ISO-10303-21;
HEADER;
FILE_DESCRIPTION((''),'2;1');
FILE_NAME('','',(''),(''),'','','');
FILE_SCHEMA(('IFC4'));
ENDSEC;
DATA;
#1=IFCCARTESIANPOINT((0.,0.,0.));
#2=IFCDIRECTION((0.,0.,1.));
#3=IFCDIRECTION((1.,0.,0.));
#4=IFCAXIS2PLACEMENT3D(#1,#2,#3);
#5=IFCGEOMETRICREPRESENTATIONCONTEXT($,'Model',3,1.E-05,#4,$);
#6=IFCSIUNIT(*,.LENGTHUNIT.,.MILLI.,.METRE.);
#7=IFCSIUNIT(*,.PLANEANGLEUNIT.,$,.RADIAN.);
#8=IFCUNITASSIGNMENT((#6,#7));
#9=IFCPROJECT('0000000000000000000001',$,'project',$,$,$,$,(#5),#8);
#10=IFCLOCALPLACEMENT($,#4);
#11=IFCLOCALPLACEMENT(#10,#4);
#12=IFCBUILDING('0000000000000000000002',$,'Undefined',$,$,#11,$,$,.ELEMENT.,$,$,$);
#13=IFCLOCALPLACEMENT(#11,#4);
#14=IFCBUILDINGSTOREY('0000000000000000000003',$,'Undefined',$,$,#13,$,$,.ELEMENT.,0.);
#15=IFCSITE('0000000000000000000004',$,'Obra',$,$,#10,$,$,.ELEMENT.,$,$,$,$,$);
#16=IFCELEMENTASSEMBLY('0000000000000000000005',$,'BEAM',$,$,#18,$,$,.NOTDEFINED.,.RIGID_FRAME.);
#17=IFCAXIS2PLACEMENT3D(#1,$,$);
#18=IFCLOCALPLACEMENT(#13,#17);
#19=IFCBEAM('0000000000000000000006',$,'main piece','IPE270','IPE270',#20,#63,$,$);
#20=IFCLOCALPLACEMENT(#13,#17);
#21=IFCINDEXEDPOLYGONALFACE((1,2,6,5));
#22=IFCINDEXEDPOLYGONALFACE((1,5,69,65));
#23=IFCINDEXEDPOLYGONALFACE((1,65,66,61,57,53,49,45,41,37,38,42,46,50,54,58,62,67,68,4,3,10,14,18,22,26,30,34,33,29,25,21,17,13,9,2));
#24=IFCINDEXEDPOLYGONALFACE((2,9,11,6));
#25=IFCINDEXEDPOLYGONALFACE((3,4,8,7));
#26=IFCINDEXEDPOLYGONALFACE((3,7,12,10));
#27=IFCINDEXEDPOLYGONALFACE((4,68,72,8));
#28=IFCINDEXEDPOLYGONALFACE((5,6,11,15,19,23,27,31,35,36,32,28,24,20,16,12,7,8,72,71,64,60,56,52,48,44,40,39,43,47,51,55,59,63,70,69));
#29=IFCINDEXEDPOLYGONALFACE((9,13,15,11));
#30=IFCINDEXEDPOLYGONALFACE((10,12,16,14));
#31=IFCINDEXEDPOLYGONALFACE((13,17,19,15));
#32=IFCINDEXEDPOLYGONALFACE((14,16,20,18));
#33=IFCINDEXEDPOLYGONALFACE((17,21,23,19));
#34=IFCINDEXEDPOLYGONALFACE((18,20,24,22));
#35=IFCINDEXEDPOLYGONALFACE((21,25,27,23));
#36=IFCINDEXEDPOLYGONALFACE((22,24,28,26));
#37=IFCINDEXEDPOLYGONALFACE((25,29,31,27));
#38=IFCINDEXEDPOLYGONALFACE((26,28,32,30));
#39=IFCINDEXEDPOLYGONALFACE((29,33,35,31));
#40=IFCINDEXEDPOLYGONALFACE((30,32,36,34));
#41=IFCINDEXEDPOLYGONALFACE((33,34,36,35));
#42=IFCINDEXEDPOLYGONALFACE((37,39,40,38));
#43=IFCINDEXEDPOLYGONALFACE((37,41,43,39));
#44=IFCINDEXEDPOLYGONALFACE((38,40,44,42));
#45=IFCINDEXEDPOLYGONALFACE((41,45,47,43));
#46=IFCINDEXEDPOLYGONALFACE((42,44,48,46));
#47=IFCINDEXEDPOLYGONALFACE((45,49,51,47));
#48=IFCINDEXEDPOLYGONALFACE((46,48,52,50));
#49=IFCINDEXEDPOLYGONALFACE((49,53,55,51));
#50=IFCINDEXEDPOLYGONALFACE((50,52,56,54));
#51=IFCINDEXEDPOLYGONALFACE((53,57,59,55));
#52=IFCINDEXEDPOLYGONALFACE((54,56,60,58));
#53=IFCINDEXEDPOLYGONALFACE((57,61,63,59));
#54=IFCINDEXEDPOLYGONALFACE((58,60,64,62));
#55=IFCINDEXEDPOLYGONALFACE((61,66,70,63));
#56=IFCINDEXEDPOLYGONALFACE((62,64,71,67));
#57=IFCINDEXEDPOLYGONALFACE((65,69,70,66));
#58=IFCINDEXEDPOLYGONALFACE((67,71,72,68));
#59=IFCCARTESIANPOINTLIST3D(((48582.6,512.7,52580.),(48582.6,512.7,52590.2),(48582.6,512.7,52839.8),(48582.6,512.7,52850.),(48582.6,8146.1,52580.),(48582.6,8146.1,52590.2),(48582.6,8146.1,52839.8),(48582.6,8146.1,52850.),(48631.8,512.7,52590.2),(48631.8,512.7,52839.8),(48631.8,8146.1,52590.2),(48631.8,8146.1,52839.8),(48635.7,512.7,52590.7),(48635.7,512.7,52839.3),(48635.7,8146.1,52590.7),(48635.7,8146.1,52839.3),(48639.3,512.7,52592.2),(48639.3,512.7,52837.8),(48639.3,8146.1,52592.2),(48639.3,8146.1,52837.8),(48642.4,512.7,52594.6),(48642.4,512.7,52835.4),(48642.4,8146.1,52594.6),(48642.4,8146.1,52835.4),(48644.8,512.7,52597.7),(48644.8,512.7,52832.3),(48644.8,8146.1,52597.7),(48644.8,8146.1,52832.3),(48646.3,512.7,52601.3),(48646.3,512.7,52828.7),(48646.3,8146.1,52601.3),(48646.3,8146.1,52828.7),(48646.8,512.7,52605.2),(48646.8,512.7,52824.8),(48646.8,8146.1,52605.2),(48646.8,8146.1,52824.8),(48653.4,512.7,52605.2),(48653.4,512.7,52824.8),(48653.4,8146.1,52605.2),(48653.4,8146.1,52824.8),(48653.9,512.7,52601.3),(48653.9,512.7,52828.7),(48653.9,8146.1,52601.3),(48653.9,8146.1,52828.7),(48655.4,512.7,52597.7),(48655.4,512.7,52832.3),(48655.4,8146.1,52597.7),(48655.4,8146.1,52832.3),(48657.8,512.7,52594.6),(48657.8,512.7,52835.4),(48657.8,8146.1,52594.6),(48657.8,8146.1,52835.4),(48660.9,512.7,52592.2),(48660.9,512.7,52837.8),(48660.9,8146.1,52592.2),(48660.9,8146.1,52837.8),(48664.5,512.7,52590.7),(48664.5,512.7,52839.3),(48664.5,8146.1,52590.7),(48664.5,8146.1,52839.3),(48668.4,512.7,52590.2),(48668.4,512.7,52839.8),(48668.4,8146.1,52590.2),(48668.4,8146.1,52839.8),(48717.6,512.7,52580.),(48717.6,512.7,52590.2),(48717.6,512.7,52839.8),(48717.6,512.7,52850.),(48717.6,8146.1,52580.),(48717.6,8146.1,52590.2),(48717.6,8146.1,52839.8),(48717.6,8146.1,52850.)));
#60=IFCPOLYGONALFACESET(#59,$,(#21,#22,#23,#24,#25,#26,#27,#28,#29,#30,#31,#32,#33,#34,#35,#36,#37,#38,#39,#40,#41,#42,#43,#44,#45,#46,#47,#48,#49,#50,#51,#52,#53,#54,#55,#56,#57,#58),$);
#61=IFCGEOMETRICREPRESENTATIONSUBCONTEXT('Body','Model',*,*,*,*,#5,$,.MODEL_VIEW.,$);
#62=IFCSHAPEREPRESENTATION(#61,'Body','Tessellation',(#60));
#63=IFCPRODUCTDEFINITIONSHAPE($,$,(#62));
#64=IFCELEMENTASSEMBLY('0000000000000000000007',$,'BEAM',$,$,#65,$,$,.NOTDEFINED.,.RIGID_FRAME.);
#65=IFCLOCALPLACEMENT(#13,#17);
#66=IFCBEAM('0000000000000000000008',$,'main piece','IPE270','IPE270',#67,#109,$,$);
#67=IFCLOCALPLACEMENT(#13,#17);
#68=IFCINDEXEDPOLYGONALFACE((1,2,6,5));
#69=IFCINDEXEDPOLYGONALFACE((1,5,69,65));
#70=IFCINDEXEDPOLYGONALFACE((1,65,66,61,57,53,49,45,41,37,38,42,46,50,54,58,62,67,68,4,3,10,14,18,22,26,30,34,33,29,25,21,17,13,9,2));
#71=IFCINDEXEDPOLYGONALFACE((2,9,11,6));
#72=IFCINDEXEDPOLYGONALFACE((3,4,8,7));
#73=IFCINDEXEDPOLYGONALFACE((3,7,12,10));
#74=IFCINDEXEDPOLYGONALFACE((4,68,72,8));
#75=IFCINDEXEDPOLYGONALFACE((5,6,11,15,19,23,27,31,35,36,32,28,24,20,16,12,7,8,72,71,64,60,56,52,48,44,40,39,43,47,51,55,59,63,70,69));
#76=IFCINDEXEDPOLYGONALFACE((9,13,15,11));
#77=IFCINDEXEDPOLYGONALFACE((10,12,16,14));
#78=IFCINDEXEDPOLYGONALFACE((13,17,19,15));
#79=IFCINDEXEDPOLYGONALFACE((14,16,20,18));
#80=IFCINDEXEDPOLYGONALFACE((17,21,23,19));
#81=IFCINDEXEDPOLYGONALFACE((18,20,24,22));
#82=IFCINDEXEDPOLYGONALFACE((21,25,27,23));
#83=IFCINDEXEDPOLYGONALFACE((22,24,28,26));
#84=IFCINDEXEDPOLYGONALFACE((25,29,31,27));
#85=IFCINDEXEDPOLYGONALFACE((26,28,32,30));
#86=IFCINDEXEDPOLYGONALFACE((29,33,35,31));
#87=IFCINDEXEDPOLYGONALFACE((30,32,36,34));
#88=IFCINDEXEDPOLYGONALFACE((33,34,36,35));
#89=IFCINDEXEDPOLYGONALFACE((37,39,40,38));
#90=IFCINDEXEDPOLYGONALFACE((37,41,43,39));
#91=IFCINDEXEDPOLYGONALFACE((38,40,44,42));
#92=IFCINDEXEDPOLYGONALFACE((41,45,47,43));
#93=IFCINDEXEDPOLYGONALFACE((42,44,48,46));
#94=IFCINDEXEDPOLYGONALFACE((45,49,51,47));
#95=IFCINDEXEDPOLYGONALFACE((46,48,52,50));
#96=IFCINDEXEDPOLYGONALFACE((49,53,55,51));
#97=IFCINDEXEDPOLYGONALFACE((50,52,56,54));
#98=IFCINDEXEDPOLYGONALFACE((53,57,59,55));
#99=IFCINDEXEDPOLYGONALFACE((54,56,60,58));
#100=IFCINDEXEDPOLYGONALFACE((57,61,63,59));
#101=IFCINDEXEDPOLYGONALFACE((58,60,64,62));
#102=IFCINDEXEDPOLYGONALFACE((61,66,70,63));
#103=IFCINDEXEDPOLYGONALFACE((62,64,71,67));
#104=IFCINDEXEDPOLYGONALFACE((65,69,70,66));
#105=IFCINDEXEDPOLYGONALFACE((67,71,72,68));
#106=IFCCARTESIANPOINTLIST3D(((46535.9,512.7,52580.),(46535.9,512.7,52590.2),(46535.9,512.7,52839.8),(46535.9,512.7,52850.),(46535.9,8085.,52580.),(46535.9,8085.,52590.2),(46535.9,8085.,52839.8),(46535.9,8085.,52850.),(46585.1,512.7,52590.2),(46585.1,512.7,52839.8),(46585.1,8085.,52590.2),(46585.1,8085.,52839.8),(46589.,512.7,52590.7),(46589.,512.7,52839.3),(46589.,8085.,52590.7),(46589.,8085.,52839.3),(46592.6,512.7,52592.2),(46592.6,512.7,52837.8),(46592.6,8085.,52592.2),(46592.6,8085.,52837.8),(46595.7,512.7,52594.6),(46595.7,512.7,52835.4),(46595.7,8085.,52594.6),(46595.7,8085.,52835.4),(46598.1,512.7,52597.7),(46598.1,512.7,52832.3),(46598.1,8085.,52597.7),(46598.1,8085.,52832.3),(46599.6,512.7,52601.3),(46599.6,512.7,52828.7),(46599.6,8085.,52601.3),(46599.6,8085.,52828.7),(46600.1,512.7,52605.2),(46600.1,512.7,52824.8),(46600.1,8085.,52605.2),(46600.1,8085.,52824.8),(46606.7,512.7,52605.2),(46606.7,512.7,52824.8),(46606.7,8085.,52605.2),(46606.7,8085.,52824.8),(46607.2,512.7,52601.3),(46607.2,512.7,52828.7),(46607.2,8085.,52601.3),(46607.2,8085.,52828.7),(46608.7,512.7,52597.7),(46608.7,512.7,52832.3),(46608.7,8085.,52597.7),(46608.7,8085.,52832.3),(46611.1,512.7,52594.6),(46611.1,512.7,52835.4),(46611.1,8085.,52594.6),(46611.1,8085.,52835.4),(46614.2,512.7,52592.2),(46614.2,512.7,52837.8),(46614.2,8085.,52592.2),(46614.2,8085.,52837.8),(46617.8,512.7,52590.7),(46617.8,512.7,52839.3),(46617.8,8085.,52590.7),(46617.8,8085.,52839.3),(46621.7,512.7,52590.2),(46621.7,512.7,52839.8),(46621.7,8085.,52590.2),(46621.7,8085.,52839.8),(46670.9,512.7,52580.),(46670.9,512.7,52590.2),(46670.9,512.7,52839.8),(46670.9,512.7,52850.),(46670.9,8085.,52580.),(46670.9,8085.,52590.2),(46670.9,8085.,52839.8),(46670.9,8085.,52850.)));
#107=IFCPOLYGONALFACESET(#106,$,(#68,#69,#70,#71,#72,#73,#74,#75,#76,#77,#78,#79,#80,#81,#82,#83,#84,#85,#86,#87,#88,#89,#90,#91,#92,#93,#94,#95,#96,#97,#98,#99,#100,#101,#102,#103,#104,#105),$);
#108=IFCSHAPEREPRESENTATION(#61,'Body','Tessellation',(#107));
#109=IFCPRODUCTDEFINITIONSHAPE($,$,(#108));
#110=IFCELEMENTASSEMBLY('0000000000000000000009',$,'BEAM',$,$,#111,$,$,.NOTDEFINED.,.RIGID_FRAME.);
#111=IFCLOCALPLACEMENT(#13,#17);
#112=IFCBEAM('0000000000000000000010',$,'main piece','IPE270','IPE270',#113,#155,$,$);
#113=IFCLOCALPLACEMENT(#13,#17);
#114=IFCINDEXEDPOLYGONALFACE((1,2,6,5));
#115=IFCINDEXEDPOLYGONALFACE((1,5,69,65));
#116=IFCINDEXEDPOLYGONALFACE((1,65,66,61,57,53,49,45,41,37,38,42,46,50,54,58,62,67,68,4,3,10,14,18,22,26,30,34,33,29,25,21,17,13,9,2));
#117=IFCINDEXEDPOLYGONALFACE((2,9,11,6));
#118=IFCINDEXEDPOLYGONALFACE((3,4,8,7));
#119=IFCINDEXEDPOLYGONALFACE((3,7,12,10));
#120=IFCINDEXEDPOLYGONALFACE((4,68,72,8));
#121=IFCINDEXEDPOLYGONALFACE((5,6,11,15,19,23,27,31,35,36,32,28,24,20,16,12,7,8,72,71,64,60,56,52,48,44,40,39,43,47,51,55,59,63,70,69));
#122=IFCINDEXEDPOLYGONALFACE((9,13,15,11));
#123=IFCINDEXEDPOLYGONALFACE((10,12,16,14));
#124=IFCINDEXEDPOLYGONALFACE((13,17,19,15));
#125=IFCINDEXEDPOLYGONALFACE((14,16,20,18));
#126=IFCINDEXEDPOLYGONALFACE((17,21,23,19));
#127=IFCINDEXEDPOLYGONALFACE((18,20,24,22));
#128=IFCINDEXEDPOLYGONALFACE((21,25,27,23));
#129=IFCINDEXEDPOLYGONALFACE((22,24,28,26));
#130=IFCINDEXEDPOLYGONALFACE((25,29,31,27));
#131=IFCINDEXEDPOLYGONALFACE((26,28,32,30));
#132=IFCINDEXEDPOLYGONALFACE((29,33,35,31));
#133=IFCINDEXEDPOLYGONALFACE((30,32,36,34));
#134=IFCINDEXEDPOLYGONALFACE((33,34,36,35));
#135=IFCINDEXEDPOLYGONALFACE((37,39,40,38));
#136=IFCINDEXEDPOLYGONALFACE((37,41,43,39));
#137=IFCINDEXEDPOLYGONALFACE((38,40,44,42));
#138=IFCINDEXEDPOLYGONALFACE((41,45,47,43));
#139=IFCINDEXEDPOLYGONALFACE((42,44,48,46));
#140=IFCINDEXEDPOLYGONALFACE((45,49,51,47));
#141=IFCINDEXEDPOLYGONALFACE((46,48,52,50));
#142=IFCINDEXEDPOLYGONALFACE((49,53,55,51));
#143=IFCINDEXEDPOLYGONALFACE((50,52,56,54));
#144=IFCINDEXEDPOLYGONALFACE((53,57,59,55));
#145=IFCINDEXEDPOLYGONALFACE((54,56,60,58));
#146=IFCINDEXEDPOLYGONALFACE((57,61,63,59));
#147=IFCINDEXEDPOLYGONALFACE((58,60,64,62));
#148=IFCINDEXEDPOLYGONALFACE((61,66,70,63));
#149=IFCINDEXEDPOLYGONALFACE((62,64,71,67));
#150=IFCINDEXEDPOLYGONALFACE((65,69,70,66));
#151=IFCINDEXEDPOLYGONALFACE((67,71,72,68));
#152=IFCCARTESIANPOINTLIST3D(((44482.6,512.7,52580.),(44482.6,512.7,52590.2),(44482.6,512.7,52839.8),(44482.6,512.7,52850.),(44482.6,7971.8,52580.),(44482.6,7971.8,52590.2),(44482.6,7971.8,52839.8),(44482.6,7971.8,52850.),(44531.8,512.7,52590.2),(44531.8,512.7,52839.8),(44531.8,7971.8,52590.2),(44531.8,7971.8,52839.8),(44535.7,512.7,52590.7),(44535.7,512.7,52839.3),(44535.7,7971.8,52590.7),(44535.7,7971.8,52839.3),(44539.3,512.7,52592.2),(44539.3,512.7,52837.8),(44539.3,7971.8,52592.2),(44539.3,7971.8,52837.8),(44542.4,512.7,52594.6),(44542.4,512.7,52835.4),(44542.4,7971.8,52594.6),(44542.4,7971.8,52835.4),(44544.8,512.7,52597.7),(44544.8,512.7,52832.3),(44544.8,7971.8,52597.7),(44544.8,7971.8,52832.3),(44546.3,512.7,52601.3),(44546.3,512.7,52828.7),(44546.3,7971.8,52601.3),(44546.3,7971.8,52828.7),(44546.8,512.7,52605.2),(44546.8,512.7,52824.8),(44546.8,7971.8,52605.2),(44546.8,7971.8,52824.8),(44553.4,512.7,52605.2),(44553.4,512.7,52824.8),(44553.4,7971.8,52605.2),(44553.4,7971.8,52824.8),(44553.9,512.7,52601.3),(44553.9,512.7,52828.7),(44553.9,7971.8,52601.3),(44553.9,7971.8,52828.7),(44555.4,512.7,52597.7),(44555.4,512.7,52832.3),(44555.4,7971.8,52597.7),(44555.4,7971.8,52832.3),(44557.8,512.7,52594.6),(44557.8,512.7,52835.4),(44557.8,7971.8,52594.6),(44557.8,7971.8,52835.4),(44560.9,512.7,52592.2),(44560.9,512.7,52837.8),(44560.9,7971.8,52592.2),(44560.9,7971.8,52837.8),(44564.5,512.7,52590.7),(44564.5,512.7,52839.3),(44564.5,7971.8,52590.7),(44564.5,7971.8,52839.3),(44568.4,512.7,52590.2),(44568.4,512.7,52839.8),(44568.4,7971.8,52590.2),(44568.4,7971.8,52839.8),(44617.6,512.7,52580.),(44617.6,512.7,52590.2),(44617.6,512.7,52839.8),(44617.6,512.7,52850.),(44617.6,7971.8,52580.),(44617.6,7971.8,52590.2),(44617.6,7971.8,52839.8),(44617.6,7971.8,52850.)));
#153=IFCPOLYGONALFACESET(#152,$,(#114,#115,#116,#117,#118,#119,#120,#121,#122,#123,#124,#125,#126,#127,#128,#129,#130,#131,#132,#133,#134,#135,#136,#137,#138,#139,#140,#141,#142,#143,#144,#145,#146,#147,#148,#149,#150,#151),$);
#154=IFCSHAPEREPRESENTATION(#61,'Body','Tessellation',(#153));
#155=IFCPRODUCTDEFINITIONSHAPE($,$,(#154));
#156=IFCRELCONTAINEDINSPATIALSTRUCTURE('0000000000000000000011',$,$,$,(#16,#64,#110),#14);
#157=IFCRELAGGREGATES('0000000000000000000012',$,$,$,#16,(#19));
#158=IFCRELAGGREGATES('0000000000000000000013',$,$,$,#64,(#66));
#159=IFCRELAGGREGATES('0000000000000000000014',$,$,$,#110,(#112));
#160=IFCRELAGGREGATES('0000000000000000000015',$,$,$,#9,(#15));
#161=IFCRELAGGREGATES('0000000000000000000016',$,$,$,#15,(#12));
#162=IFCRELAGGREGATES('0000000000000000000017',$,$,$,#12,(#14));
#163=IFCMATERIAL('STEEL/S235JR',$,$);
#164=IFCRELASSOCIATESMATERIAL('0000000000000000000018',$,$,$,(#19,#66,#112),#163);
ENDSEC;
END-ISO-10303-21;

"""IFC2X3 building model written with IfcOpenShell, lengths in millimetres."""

from ifc_helpers import new_model, si_unit, frame, origin_with_axes, origin_2d_with_axis, place, context, subcontext, project, spatial, i_section, extrude, material, element, aggregate, save


model = new_model("IFC2X3")

# Units and contexts
model_context = context("Model", 3, precision=1e-05, world=origin_with_axes())
body_context = subcontext(model_context, "Body", "Model", "MODEL_VIEW")
ifc_project = project(units=[si_unit("LENGTHUNIT", "METRE", prefix="MILLI"), si_unit("PLANEANGLEUNIT", "RADIAN")], contexts=[model_context])

# Site, building, storey
site_placement = place(None, origin_with_axes())
site = spatial("IfcSite", under=ifc_project, at=site_placement, Name="Obra", CompositionType="ELEMENT")
building_placement = place(site_placement, origin_with_axes())
building = spatial("IfcBuilding", under=site, at=building_placement, Name="Undefined", CompositionType="ELEMENT")
storey_placement = place(building_placement, origin_with_axes())
storey = spatial("IfcBuildingStorey", under=building, at=storey_placement, Name="Undefined", CompositionType="ELEMENT", Elevation=0.0)

# Shared definitions
ifc_material_1 = material(Name="STEEL/S235JR")

# Element assemblies, beams
assembly_1_placement = place(storey_placement, origin_with_axes())
assembly_1 = element("IfcElementAssembly", 1, at=assembly_1_placement, inside=storey, Name="BEAM", AssemblyPlace="NOTDEFINED", PredefinedType="RIGID_FRAME")
beam_1_placement = place(assembly_1_placement, frame((48650.1, 512.7, 52715.0), z_axis=(0.0, 0.0, 1.0), x_axis=(0.0, 1.0, 0.0)))
beam_1 = element("IfcBeam", 2, at=beam_1_placement, material=ifc_material_1, Name="main piece", Description="IPE270", ObjectType="IPE270", context=body_context, shape_type="SweptSolid", body=[
    extrude(i_section(OverallWidth=135.0, OverallDepth=270.0, WebThickness=6.6, FlangeThickness=10.2, FilletRadius=15.0, at=origin_2d_with_axis()), frame((7633.4, 0.0, 0.0), z_axis=(-1.0, 0.0, 0.0), x_axis=(0.0, -1.0, 0.0)), (0.0, 0.0, 1.0), 7633.4),
])
aggregate(assembly_1, [beam_1])
assembly_2_placement = place(storey_placement, origin_with_axes())
assembly_2 = element("IfcElementAssembly", 3, at=assembly_2_placement, inside=storey, Name="BEAM", AssemblyPlace="NOTDEFINED", PredefinedType="RIGID_FRAME")
beam_2_placement = place(assembly_2_placement, frame((46603.4, 8085.0, 52715.0), z_axis=(0.0, 0.0, 1.0), x_axis=(0.0, -1.0, 0.0)))
beam_2 = element("IfcBeam", 4, at=beam_2_placement, material=ifc_material_1, Name="main piece", Description="IPE270", ObjectType="IPE270", context=body_context, shape_type="SweptSolid", body=[
    extrude(i_section(OverallWidth=135.0, OverallDepth=270.0, WebThickness=6.6, FlangeThickness=10.2, FilletRadius=15.0, at=origin_2d_with_axis()), frame((7572.3, 0.0, 0.0), z_axis=(-1.0, 0.0, 0.0), x_axis=(0.0, -1.0, 0.0)), (0.0, 0.0, 1.0), 7572.3),
])
aggregate(assembly_2, [beam_2])
assembly_3_placement = place(storey_placement, origin_with_axes())
assembly_3 = element("IfcElementAssembly", 5, at=assembly_3_placement, inside=storey, Name="BEAM", AssemblyPlace="NOTDEFINED", PredefinedType="RIGID_FRAME")
beam_3_placement = place(assembly_3_placement, frame((44550.1, 512.7, 52715.0), z_axis=(0.0, 0.0, 1.0), x_axis=(0.0, 1.0, 0.0)))
beam_3 = element("IfcBeam", 6, at=beam_3_placement, material=ifc_material_1, Name="main piece", Description="IPE270", ObjectType="IPE270", context=body_context, shape_type="SweptSolid", body=[
    extrude(i_section(OverallWidth=135.0, OverallDepth=270.0, WebThickness=6.6, FlangeThickness=10.2, FilletRadius=15.0, at=origin_2d_with_axis()), frame((7459.1, 0.0, 0.0), z_axis=(-1.0, 0.0, 0.0), x_axis=(0.0, -1.0, 0.0)), (0.0, 0.0, 1.0), 7459.1),
])
aggregate(assembly_3, [beam_3])

save(model, "model.ifc")
